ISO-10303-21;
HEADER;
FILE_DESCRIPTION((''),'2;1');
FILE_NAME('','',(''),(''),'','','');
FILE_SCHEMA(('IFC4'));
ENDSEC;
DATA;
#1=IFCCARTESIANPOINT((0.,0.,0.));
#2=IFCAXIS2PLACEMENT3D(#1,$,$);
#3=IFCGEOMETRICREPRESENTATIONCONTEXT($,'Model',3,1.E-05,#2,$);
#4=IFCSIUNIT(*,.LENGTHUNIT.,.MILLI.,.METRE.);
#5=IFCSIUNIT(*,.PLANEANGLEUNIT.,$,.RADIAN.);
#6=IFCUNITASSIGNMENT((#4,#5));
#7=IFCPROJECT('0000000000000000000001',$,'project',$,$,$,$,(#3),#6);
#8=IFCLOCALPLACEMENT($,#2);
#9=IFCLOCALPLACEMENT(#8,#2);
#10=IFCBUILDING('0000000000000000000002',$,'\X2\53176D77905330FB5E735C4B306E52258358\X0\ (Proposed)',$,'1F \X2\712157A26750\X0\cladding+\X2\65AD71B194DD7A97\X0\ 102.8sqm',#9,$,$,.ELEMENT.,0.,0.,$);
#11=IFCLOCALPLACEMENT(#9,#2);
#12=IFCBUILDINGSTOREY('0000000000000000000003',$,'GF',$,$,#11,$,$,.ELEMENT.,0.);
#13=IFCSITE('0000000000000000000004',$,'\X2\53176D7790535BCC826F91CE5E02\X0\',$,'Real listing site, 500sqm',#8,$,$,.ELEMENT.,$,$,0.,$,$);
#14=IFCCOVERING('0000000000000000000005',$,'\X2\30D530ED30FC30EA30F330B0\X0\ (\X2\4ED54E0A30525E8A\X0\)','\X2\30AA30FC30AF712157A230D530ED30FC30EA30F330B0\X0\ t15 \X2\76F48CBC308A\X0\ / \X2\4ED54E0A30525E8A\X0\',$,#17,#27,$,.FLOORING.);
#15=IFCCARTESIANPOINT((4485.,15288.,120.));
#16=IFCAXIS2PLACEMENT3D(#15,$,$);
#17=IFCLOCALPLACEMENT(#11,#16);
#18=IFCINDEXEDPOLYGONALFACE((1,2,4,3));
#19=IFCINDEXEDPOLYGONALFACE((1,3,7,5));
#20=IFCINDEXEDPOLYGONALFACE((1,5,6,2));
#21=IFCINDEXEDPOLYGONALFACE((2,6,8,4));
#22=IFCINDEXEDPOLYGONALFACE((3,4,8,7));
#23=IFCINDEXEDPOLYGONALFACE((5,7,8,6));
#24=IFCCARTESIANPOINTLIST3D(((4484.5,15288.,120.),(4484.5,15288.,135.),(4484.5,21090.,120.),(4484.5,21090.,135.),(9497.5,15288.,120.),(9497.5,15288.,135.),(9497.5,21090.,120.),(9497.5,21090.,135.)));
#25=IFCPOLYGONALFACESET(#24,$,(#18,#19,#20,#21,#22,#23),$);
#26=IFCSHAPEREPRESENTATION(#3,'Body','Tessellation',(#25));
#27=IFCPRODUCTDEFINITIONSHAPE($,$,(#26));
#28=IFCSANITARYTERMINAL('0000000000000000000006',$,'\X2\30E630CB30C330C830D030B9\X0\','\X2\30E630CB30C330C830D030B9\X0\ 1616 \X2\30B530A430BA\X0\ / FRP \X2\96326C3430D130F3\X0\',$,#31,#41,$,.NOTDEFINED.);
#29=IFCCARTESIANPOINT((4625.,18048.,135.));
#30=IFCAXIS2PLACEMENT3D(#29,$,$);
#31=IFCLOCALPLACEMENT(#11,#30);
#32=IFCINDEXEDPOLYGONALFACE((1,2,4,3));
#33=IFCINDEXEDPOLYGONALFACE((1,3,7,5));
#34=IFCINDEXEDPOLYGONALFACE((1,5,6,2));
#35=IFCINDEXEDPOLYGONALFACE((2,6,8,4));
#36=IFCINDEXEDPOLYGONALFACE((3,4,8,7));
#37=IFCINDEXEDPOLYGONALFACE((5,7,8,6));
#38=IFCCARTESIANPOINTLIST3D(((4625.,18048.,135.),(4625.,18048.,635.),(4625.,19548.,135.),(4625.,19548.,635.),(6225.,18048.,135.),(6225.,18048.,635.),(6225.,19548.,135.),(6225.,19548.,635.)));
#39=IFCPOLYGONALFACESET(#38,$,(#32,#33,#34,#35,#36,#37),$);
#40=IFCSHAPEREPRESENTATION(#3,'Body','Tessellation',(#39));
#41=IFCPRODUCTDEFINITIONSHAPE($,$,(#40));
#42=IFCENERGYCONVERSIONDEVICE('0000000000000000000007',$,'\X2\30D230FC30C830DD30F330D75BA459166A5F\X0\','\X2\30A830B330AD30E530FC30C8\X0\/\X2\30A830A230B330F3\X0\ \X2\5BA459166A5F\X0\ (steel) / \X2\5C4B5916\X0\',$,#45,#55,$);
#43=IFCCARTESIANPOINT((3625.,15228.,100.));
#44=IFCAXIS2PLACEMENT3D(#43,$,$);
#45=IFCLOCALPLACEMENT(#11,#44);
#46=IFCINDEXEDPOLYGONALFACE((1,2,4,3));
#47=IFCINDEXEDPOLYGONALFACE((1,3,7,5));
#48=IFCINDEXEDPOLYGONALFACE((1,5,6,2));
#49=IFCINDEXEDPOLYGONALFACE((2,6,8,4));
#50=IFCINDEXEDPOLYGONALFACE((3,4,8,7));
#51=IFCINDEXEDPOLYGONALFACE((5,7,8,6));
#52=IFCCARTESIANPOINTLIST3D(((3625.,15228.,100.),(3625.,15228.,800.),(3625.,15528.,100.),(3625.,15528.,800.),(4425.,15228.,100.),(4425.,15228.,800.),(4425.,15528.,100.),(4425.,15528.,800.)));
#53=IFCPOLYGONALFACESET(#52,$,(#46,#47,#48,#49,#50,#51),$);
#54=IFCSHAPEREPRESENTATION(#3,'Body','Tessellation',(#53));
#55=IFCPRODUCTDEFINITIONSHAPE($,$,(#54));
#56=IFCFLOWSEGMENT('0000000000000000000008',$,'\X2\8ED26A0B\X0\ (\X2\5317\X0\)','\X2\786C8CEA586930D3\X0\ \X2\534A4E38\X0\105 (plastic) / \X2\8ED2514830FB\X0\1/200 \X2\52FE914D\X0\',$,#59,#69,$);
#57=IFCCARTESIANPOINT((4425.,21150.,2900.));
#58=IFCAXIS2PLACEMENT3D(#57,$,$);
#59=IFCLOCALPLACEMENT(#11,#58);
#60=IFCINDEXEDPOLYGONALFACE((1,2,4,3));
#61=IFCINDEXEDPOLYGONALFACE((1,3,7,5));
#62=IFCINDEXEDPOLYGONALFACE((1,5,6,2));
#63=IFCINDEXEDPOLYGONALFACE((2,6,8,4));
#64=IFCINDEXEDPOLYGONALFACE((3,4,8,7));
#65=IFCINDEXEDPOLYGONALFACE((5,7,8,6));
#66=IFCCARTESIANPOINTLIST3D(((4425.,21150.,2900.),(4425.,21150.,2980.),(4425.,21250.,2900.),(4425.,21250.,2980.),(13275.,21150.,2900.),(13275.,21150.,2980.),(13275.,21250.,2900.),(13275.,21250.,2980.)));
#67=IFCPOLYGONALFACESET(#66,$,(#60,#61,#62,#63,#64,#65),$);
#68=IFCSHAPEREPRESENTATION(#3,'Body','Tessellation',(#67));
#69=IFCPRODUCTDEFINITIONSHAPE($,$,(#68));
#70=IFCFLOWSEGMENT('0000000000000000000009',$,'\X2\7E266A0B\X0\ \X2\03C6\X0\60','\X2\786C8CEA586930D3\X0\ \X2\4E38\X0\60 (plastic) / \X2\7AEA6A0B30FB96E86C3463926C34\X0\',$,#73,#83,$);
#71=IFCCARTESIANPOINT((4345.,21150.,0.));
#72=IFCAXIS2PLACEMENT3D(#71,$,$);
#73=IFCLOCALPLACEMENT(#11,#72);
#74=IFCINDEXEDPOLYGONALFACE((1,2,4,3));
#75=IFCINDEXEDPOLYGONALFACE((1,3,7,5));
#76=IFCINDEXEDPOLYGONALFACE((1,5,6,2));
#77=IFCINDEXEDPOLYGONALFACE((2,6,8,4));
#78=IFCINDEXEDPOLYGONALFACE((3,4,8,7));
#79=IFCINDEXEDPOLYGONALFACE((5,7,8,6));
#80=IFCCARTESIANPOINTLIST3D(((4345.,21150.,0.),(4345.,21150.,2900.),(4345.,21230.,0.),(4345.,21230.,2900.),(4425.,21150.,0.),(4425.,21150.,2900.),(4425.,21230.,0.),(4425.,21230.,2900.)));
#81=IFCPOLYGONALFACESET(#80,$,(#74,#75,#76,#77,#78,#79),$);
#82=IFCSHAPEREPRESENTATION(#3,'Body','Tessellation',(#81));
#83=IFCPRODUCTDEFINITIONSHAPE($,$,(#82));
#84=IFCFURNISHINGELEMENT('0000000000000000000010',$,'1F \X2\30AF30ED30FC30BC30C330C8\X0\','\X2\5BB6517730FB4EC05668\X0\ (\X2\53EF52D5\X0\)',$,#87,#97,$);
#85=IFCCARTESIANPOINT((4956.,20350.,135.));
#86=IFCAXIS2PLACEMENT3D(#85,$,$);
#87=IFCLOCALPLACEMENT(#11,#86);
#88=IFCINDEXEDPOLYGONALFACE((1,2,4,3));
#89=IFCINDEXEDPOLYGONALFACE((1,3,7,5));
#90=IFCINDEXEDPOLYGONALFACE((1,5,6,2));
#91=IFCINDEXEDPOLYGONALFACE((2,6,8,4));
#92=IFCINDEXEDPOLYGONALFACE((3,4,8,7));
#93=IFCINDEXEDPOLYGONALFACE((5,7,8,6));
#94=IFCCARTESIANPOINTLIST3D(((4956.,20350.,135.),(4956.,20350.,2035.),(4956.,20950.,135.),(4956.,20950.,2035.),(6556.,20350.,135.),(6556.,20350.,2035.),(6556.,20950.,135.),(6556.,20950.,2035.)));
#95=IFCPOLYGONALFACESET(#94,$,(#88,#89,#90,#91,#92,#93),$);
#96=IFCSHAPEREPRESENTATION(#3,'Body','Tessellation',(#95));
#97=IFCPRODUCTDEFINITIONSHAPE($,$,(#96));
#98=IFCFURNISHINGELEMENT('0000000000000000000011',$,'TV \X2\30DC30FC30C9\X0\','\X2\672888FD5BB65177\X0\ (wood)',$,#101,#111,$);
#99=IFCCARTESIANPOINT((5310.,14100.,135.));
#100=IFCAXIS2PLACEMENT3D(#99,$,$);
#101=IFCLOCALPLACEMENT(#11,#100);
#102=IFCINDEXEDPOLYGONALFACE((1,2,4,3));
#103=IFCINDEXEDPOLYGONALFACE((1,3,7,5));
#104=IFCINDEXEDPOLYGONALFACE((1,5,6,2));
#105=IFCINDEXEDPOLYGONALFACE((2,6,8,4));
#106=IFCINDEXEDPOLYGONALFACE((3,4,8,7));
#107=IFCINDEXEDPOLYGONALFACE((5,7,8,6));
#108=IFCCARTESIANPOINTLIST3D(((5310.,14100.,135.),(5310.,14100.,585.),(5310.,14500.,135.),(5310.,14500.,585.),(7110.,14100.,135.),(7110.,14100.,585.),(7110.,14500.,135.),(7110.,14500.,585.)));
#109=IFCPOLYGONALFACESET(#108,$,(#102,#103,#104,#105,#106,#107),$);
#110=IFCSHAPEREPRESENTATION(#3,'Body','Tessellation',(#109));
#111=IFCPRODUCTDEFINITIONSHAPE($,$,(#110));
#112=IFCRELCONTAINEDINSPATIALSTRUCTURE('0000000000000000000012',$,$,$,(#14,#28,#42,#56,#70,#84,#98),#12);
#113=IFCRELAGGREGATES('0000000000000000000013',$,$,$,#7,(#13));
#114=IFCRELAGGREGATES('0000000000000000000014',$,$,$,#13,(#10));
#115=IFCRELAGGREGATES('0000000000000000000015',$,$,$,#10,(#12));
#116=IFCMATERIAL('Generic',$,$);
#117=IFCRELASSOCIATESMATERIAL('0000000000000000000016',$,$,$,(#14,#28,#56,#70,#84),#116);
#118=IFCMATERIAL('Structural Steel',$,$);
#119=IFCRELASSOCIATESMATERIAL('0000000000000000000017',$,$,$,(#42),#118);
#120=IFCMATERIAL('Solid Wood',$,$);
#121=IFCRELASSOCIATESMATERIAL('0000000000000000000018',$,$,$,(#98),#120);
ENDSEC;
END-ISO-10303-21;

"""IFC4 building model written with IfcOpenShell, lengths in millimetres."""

from ifc_helpers import new_model, si_unit, frame, frame_2d, origin, place, context, project, spatial, rectangle, extrude, material, element, save


model = new_model("IFC4")

# Units and contexts
model_context = context("Model", 3, precision=1e-05, world=origin())
ifc_project = project(units=[si_unit("LENGTHUNIT", "METRE", prefix="MILLI"), si_unit("PLANEANGLEUNIT", "RADIAN")], contexts=[model_context])

# Site, building, storey
site_placement = place(None, origin())
site = spatial("IfcSite", under=ifc_project, at=site_placement, Name="北海道富良野市", ObjectType="Real listing site, 500sqm", CompositionType="ELEMENT", RefElevation=0.0)
building_placement = place(site_placement, origin())
building = spatial("IfcBuilding", under=site, at=building_placement, Name="北海道・平屋の別荘 (Proposed)", ObjectType="1F 無垢材cladding+断熱铝窗 102.8sqm", CompositionType="ELEMENT", ElevationOfRefHeight=0.0, ElevationOfTerrain=0.0)
storey_placement = place(building_placement, origin())
storey = spatial("IfcBuildingStorey", under=building, at=storey_placement, Name="GF", CompositionType="ELEMENT", Elevation=0.0)

# Shared definitions
ifc_material_1 = material(Name="Solid Wood")

# Shared definitions
ifc_material_2 = material(Name="Structural Steel")

# Covering
ifc_material_3 = material(Name="Generic")
covering_placement = place(storey_placement, frame((4485.0, 15288.0, 120.0)))
element("IfcCovering", 1, at=covering_placement, inside=storey, material=ifc_material_3, Name="フローリング (仕上げ床)", Description="オーク無垢フローリング t15 直貼り / 仕上げ床", PredefinedType="FLOORING", context=model_context, shape_type="SweptSolid", body=[
    extrude(rectangle(XDim=5013.0, YDim=5802.0, at=frame_2d((2506.0, 2901.0))), frame((4485.0, 15288.0, 120.0)), (0.0, 0.0, 1.0), 15.0),
])

# Sanitary terminal
sanitary_terminal_placement = place(storey_placement, frame((4625.0, 18048.0, 135.0)))
element("IfcSanitaryTerminal", 2, at=sanitary_terminal_placement, inside=storey, material=ifc_material_3, Name="ユニットバス", Description="ユニットバス 1616 サイズ / FRP 防水パン", PredefinedType="NOTDEFINED", context=model_context, shape_type="SweptSolid", body=[
    extrude(rectangle(XDim=1600.0, YDim=1500.0, at=frame_2d((800.0, 750.0))), frame((4625.0, 18048.0, 135.0)), (0.0, 0.0, 1.0), 500.0),
])

# Energy conversion device
energy_conversion_device_placement = place(storey_placement, frame((3625.0, 15228.0, 100.0)))
element("IfcEnergyConversionDevice", 3, at=energy_conversion_device_placement, inside=storey, material=ifc_material_2, Name="ヒートポンプ室外機", Description="エコキュート/エアコン 室外機 (steel) / 屋外", context=model_context, shape_type="SweptSolid", body=[
    extrude(rectangle(XDim=800.0, YDim=300.0, at=frame_2d((400.0, 150.0))), frame((3625.0, 15228.0, 100.0)), (0.0, 0.0, 1.0), 700.0),
])

# Flow segments
flow_segment_1_placement = place(storey_placement, frame((4425.0, 21150.0, 2900.0)))
element("IfcFlowSegment", 4, at=flow_segment_1_placement, inside=storey, material=ifc_material_3, Name="軒樋 (北)", Description="硬質塩ビ 半丸105 (plastic) / 軒先・1/200 勾配", context=model_context, shape_type="SweptSolid", body=[
    extrude(rectangle(XDim=8850.0, YDim=100.0, at=frame_2d((4425.0, 50.0))), frame((4425.0, 21150.0, 2900.0)), (0.0, 0.0, 1.0), 80.0),
])
flow_segment_2_placement = place(storey_placement, frame((4345.0, 21150.0, 0.0)))
element("IfcFlowSegment", 5, at=flow_segment_2_placement, inside=storey, material=ifc_material_3, Name="縦樋 φ60", Description="硬質塩ビ 丸60 (plastic) / 竪樋・雨水排水", context=model_context, shape_type="SweptSolid", body=[
    extrude(rectangle(XDim=80.0, YDim=80.0, at=frame_2d((40.0, 40.0))), frame((4345.0, 21150.0, 0.0)), (0.0, 0.0, 1.0), 2900.0),
])

# Furnishing elements
furnishing_1_placement = place(storey_placement, frame((4956.0, 20350.0, 135.0)))
element("IfcFurnishingElement", 6, at=furnishing_1_placement, inside=storey, material=ifc_material_3, Name="1F クローゼット", Description="家具・什器 (可動)", context=model_context, shape_type="SweptSolid", body=[
    extrude(rectangle(XDim=1600.0, YDim=600.0, at=frame_2d((800.0, 300.0))), frame((4956.0, 20350.0, 135.0)), (0.0, 0.0, 1.0), 1900.0),
])
furnishing_2_placement = place(storey_placement, frame((5310.0, 14100.0, 135.0)))
element("IfcFurnishingElement", 7, at=furnishing_2_placement, inside=storey, material=ifc_material_1, Name="TV ボード", Description="木製家具 (wood)", context=model_context, shape_type="SweptSolid", body=[
    extrude(rectangle(XDim=1800.0, YDim=400.0, at=frame_2d((900.0, 200.0))), frame((5310.0, 14100.0, 135.0)), (0.0, 0.0, 1.0), 450.0),
])

save(model, "model.ifc")
